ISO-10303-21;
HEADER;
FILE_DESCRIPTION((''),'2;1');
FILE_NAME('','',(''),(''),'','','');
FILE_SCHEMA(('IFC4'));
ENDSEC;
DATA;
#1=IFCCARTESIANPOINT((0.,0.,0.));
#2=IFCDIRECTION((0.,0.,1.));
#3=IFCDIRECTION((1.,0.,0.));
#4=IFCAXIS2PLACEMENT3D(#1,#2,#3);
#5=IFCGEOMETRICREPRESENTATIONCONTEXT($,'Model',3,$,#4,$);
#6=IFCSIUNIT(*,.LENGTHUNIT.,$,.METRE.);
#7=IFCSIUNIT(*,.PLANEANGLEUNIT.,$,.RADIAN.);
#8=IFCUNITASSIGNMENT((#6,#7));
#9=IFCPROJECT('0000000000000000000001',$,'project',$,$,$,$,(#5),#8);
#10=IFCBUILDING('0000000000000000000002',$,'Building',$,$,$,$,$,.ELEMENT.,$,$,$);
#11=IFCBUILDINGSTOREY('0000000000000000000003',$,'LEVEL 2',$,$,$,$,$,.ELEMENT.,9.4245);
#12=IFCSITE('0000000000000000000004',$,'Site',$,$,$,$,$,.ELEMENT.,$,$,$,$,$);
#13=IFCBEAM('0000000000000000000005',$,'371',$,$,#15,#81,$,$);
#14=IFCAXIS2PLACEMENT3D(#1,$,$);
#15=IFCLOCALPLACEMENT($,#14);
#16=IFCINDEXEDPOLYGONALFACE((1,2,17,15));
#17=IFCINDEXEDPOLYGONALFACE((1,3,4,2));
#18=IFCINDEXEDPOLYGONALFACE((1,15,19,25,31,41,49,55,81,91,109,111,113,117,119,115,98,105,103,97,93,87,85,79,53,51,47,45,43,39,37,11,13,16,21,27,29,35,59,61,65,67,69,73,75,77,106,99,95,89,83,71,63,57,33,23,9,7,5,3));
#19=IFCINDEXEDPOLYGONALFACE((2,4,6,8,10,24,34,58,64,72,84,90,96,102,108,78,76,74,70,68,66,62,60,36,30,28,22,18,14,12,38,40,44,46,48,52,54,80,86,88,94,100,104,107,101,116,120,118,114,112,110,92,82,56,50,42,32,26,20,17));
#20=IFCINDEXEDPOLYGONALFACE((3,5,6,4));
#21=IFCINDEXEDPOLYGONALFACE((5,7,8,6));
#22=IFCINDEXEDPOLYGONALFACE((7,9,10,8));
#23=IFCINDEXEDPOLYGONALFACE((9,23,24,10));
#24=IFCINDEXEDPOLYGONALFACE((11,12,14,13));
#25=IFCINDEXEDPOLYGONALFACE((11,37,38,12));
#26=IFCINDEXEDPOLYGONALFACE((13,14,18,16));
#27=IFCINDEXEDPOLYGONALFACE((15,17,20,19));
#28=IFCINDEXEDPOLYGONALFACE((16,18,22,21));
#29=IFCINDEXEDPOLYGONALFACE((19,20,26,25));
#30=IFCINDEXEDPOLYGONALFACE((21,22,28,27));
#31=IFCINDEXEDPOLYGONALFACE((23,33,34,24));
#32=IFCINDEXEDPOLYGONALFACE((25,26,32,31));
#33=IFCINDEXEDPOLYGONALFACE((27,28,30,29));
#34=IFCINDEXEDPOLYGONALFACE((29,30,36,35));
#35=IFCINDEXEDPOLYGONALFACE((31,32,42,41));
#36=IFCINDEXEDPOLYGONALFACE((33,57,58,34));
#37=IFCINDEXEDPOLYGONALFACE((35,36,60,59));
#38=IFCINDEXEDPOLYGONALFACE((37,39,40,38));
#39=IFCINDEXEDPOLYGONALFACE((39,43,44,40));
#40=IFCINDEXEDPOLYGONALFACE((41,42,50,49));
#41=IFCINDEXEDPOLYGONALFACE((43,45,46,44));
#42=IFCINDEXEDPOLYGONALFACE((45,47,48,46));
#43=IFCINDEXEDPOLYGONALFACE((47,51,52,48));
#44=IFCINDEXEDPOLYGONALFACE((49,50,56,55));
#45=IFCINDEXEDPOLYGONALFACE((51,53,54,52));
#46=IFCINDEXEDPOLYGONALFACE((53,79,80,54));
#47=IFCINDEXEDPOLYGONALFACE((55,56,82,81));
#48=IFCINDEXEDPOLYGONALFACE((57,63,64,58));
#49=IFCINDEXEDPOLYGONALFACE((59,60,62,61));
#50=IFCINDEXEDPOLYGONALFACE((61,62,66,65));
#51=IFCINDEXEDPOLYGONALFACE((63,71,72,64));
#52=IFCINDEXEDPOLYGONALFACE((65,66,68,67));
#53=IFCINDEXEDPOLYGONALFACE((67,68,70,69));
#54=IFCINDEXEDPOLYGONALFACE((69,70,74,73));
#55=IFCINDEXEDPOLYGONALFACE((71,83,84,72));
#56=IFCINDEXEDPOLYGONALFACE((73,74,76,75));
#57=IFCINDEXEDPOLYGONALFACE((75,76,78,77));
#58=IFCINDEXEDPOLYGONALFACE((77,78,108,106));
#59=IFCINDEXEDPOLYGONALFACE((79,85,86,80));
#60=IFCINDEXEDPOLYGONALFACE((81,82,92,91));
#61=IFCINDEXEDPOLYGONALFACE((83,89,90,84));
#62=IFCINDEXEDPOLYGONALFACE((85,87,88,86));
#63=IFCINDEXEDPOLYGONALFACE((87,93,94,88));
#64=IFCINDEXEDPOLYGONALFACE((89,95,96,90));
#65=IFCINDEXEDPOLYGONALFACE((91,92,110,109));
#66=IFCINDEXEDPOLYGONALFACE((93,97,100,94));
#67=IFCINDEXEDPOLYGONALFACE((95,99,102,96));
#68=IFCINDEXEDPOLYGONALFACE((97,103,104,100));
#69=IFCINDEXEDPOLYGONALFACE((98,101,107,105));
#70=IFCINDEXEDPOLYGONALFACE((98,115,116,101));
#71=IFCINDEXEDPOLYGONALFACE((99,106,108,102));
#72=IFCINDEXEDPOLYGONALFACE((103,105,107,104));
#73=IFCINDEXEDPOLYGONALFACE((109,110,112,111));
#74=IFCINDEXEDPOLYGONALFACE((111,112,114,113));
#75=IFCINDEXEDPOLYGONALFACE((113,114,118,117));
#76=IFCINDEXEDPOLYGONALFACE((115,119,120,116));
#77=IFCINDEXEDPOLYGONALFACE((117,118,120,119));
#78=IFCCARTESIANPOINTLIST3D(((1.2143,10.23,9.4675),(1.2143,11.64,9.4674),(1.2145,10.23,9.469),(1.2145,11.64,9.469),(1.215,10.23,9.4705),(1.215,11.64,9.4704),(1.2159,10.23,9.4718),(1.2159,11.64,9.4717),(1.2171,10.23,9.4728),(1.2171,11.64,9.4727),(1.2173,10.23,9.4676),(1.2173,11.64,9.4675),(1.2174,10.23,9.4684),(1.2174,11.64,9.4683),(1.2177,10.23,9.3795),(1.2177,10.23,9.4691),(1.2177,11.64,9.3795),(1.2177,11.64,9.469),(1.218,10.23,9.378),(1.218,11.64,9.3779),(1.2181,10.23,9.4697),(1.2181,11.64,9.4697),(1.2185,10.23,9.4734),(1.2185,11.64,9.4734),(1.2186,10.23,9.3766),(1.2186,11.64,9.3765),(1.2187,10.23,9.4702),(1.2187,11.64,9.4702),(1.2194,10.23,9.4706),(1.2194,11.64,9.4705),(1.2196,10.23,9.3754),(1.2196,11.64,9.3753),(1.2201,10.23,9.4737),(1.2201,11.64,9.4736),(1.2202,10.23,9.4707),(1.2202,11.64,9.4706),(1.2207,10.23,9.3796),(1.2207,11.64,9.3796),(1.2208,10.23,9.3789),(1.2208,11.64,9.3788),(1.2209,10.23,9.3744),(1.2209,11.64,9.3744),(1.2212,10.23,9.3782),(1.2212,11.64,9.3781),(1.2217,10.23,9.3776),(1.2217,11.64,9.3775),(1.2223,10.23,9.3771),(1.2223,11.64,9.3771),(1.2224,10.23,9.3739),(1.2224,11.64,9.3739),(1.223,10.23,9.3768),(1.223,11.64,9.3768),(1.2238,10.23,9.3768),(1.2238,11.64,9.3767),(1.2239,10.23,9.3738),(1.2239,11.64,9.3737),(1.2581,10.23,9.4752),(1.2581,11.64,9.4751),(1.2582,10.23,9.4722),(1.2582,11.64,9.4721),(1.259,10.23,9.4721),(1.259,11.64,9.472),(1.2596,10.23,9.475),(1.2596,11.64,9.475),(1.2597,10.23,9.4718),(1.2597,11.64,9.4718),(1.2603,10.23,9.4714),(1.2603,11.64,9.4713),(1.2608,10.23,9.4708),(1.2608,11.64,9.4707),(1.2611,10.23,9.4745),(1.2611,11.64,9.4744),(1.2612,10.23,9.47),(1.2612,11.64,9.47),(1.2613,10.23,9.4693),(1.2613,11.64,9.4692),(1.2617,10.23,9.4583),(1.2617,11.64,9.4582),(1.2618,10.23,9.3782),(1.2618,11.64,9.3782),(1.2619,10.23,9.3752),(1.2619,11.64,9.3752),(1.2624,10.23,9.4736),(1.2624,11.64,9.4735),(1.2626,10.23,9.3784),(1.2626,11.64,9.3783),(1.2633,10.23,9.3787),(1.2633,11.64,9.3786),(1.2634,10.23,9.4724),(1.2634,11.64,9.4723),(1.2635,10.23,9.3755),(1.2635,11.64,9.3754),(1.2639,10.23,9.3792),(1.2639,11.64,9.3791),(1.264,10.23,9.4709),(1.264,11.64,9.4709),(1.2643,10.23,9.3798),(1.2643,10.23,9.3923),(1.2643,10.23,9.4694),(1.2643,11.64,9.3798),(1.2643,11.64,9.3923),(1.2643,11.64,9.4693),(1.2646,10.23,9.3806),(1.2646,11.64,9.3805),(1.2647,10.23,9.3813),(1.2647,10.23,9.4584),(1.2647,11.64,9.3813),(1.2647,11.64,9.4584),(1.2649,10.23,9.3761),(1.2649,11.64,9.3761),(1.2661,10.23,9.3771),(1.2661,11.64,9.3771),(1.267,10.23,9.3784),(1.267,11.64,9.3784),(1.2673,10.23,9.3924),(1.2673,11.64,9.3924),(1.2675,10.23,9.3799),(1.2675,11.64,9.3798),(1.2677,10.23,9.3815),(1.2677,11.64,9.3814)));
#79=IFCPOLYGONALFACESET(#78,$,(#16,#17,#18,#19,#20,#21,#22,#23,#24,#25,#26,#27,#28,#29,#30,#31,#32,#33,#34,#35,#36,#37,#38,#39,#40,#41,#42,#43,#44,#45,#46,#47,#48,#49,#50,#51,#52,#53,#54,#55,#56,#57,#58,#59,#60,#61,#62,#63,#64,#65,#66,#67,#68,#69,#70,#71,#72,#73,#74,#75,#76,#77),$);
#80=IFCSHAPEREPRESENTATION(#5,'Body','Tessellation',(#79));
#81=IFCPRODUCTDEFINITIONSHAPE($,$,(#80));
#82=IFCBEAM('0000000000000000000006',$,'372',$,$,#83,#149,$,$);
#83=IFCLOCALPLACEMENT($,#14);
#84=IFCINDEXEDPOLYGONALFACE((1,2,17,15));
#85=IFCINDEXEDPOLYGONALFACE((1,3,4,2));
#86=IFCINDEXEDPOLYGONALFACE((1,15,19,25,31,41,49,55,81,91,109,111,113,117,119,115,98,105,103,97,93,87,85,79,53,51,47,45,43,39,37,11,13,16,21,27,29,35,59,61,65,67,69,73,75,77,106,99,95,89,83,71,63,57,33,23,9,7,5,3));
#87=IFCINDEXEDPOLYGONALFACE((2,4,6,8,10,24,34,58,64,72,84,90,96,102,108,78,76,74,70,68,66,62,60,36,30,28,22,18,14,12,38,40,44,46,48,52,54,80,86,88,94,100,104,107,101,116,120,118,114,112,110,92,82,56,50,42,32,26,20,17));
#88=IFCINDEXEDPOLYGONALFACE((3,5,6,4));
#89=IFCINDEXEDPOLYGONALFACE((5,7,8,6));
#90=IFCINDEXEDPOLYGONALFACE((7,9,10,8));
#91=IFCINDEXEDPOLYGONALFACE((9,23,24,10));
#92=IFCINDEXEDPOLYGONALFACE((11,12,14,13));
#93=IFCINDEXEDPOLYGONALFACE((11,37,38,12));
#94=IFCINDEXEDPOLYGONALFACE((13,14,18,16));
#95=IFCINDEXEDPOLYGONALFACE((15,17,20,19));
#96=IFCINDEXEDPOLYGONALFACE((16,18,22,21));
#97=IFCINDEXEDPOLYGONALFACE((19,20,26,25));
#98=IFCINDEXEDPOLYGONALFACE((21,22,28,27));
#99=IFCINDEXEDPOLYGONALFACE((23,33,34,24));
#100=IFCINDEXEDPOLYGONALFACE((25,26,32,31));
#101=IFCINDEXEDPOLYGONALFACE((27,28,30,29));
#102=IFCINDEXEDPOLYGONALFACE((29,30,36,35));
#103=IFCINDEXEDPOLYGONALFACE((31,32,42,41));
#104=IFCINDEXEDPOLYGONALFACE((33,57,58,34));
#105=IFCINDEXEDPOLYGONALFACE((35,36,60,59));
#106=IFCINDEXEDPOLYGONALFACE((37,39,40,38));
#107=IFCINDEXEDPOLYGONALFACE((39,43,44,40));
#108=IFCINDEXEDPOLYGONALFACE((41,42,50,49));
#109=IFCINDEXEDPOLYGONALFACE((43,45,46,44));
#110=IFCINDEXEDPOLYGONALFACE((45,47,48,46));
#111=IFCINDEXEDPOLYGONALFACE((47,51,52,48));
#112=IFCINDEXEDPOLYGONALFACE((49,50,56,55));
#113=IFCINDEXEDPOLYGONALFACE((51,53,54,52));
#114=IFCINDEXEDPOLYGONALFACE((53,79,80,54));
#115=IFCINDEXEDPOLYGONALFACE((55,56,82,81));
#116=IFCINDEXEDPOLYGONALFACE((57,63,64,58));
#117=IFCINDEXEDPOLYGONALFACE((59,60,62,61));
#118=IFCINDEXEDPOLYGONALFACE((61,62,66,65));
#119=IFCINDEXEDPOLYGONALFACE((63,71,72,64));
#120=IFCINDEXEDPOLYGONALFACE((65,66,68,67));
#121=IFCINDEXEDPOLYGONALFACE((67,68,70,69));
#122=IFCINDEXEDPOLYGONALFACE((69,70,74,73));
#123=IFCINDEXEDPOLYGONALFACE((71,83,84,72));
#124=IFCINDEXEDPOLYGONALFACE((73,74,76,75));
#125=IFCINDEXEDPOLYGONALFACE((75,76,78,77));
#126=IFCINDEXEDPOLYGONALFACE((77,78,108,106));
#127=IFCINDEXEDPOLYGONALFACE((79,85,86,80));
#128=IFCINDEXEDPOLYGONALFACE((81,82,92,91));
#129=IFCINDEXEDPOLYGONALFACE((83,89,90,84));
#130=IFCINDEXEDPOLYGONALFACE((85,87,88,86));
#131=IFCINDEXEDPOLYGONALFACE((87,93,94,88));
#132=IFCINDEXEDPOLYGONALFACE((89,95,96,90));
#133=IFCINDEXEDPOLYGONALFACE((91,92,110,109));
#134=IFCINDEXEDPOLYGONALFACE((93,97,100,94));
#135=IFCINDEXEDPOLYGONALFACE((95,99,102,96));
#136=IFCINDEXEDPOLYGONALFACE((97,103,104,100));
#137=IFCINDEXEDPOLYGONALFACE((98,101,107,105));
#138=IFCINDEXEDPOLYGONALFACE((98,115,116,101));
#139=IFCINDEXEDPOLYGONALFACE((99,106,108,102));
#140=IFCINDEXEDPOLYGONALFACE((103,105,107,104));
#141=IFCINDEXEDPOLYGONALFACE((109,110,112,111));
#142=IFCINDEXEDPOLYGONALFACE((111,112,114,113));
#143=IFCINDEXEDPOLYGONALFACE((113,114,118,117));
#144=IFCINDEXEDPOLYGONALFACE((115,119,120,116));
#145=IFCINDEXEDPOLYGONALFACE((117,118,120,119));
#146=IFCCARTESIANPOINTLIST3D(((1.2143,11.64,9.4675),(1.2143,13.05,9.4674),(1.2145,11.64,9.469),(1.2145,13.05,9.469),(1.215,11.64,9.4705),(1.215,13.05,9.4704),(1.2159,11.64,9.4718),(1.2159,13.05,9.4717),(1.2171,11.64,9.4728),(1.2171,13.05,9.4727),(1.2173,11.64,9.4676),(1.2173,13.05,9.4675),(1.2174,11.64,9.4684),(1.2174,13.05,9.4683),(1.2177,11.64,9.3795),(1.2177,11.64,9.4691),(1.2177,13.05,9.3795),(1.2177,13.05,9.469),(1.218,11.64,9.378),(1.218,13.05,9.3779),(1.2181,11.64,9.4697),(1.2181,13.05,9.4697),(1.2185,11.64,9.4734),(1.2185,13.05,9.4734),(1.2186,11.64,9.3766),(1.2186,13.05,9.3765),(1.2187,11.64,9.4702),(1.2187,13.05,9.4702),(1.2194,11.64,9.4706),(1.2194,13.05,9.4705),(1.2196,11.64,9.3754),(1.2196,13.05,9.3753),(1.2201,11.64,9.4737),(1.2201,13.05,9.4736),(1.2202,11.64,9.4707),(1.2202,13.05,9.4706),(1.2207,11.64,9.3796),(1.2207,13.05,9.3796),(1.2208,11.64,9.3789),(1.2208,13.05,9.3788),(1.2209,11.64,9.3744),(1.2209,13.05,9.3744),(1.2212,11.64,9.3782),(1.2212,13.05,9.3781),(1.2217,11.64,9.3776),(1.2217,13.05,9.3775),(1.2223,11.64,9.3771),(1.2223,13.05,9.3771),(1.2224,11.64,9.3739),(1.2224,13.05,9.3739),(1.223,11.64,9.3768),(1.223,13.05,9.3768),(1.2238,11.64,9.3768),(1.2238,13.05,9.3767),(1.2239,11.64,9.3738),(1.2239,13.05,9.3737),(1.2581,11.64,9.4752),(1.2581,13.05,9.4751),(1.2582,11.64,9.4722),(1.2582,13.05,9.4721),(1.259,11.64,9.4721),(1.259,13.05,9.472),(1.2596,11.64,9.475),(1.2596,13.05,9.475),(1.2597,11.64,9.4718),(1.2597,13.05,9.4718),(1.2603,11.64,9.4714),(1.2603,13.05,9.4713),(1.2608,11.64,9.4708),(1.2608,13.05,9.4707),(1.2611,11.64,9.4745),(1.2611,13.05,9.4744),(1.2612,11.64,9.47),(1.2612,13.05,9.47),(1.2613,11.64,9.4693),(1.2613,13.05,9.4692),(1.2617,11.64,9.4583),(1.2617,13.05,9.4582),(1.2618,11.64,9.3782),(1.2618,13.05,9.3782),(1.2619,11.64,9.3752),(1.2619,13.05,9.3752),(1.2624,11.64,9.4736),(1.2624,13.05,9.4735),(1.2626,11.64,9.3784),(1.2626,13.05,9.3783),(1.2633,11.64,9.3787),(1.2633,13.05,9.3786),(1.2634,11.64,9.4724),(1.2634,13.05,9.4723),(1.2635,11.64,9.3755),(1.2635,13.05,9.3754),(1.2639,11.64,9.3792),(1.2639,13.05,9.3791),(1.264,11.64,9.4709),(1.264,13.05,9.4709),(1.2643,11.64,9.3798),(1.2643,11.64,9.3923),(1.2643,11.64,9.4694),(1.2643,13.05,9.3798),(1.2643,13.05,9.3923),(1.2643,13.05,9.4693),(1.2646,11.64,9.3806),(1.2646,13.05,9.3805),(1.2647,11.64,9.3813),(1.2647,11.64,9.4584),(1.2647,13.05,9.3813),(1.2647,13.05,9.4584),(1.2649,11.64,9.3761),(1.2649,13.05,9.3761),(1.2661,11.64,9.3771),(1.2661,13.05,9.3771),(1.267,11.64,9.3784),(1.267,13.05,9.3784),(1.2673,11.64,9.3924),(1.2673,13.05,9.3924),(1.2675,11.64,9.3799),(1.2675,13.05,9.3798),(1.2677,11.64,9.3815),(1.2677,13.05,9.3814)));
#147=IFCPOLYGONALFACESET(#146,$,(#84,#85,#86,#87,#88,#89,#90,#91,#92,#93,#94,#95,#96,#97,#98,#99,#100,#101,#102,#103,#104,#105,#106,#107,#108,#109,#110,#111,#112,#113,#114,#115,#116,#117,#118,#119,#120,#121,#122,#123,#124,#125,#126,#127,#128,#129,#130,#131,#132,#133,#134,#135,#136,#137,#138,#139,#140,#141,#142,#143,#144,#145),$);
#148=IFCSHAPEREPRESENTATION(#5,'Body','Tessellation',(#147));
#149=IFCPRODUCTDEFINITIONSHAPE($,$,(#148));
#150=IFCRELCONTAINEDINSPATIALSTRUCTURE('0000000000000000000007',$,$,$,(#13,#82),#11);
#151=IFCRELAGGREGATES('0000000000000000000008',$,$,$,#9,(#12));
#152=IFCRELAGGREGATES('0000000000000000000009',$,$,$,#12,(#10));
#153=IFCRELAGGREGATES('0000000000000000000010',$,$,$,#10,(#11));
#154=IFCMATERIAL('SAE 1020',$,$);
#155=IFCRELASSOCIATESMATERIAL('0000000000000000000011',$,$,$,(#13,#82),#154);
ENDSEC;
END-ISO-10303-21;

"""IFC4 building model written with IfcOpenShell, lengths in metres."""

from ifc_helpers import new_model, si_unit, frame, origin_with_axes, origin_2d_with_axis, place, context, project, spatial, c_section, extrude, material, material_profile, profile_set, profile_usage, element, save


model = new_model("IFC4")

# Units and contexts
model_context = context("Model", 3, world=origin_with_axes())
ifc_project = project(units=[si_unit("LENGTHUNIT", "METRE"), si_unit("PLANEANGLEUNIT", "RADIAN")], contexts=[model_context])

# Site, building, storey
site = spatial("IfcSite", under=ifc_project, Name="Site", CompositionType="ELEMENT")
building = spatial("IfcBuilding", under=site, Name="Building", CompositionType="ELEMENT")
storey = spatial("IfcBuildingStorey", under=building, Name="LEVEL 2", CompositionType="ELEMENT", Elevation=9.4245)

# Beams
ifc_material = material(Name="SAE 1020")
ifc_material_profile_1 = material_profile(ifc_material, c_section(Depth=0.1, Width=0.05, WallThickness=0.003, Girth=0.017, InternalFilletRadius=0.003, at=origin_2d_with_axis()))
ifc_profile_set_1 = profile_set([ifc_material_profile_1])
ifc_profile_usage_1 = profile_usage(ifc_profile_set_1, cardinal=10)
beam_1_placement = place(None, frame((1.241, 10.23, 9.4245), z_axis=(0.0, 1.0, -0.00003), x_axis=(0.999256, 0.000001, 0.038562)))
element("IfcBeam", 1, at=beam_1_placement, inside=storey, material=ifc_profile_usage_1, Name="371", context=model_context, shape_type="SweptSolid", body=[
    extrude(c_section(Depth=0.1, Width=0.05, WallThickness=0.003, Girth=0.017, InternalFilletRadius=0.003, at=origin_2d_with_axis()), origin_with_axes(), (0.0, 0.0, 1.0), 1.41),
])
ifc_material_profile_2 = material_profile(ifc_material, c_section(Depth=0.1, Width=0.05, WallThickness=0.003, Girth=0.017, InternalFilletRadius=0.003, at=origin_2d_with_axis()))
ifc_profile_set_2 = profile_set([ifc_material_profile_2])
ifc_profile_usage_2 = profile_usage(ifc_profile_set_2, cardinal=10)
beam_2_placement = place(None, frame((1.241, 11.64, 9.4245), z_axis=(0.0, 1.0, -0.00003), x_axis=(0.999256, 0.000001, 0.038562)))
element("IfcBeam", 2, at=beam_2_placement, inside=storey, material=ifc_profile_usage_2, Name="372", context=model_context, shape_type="SweptSolid", body=[
    extrude(c_section(Depth=0.1, Width=0.05, WallThickness=0.003, Girth=0.017, InternalFilletRadius=0.003, at=origin_2d_with_axis()), origin_with_axes(), (0.0, 0.0, 1.0), 1.41),
])

save(model, "model.ifc")
